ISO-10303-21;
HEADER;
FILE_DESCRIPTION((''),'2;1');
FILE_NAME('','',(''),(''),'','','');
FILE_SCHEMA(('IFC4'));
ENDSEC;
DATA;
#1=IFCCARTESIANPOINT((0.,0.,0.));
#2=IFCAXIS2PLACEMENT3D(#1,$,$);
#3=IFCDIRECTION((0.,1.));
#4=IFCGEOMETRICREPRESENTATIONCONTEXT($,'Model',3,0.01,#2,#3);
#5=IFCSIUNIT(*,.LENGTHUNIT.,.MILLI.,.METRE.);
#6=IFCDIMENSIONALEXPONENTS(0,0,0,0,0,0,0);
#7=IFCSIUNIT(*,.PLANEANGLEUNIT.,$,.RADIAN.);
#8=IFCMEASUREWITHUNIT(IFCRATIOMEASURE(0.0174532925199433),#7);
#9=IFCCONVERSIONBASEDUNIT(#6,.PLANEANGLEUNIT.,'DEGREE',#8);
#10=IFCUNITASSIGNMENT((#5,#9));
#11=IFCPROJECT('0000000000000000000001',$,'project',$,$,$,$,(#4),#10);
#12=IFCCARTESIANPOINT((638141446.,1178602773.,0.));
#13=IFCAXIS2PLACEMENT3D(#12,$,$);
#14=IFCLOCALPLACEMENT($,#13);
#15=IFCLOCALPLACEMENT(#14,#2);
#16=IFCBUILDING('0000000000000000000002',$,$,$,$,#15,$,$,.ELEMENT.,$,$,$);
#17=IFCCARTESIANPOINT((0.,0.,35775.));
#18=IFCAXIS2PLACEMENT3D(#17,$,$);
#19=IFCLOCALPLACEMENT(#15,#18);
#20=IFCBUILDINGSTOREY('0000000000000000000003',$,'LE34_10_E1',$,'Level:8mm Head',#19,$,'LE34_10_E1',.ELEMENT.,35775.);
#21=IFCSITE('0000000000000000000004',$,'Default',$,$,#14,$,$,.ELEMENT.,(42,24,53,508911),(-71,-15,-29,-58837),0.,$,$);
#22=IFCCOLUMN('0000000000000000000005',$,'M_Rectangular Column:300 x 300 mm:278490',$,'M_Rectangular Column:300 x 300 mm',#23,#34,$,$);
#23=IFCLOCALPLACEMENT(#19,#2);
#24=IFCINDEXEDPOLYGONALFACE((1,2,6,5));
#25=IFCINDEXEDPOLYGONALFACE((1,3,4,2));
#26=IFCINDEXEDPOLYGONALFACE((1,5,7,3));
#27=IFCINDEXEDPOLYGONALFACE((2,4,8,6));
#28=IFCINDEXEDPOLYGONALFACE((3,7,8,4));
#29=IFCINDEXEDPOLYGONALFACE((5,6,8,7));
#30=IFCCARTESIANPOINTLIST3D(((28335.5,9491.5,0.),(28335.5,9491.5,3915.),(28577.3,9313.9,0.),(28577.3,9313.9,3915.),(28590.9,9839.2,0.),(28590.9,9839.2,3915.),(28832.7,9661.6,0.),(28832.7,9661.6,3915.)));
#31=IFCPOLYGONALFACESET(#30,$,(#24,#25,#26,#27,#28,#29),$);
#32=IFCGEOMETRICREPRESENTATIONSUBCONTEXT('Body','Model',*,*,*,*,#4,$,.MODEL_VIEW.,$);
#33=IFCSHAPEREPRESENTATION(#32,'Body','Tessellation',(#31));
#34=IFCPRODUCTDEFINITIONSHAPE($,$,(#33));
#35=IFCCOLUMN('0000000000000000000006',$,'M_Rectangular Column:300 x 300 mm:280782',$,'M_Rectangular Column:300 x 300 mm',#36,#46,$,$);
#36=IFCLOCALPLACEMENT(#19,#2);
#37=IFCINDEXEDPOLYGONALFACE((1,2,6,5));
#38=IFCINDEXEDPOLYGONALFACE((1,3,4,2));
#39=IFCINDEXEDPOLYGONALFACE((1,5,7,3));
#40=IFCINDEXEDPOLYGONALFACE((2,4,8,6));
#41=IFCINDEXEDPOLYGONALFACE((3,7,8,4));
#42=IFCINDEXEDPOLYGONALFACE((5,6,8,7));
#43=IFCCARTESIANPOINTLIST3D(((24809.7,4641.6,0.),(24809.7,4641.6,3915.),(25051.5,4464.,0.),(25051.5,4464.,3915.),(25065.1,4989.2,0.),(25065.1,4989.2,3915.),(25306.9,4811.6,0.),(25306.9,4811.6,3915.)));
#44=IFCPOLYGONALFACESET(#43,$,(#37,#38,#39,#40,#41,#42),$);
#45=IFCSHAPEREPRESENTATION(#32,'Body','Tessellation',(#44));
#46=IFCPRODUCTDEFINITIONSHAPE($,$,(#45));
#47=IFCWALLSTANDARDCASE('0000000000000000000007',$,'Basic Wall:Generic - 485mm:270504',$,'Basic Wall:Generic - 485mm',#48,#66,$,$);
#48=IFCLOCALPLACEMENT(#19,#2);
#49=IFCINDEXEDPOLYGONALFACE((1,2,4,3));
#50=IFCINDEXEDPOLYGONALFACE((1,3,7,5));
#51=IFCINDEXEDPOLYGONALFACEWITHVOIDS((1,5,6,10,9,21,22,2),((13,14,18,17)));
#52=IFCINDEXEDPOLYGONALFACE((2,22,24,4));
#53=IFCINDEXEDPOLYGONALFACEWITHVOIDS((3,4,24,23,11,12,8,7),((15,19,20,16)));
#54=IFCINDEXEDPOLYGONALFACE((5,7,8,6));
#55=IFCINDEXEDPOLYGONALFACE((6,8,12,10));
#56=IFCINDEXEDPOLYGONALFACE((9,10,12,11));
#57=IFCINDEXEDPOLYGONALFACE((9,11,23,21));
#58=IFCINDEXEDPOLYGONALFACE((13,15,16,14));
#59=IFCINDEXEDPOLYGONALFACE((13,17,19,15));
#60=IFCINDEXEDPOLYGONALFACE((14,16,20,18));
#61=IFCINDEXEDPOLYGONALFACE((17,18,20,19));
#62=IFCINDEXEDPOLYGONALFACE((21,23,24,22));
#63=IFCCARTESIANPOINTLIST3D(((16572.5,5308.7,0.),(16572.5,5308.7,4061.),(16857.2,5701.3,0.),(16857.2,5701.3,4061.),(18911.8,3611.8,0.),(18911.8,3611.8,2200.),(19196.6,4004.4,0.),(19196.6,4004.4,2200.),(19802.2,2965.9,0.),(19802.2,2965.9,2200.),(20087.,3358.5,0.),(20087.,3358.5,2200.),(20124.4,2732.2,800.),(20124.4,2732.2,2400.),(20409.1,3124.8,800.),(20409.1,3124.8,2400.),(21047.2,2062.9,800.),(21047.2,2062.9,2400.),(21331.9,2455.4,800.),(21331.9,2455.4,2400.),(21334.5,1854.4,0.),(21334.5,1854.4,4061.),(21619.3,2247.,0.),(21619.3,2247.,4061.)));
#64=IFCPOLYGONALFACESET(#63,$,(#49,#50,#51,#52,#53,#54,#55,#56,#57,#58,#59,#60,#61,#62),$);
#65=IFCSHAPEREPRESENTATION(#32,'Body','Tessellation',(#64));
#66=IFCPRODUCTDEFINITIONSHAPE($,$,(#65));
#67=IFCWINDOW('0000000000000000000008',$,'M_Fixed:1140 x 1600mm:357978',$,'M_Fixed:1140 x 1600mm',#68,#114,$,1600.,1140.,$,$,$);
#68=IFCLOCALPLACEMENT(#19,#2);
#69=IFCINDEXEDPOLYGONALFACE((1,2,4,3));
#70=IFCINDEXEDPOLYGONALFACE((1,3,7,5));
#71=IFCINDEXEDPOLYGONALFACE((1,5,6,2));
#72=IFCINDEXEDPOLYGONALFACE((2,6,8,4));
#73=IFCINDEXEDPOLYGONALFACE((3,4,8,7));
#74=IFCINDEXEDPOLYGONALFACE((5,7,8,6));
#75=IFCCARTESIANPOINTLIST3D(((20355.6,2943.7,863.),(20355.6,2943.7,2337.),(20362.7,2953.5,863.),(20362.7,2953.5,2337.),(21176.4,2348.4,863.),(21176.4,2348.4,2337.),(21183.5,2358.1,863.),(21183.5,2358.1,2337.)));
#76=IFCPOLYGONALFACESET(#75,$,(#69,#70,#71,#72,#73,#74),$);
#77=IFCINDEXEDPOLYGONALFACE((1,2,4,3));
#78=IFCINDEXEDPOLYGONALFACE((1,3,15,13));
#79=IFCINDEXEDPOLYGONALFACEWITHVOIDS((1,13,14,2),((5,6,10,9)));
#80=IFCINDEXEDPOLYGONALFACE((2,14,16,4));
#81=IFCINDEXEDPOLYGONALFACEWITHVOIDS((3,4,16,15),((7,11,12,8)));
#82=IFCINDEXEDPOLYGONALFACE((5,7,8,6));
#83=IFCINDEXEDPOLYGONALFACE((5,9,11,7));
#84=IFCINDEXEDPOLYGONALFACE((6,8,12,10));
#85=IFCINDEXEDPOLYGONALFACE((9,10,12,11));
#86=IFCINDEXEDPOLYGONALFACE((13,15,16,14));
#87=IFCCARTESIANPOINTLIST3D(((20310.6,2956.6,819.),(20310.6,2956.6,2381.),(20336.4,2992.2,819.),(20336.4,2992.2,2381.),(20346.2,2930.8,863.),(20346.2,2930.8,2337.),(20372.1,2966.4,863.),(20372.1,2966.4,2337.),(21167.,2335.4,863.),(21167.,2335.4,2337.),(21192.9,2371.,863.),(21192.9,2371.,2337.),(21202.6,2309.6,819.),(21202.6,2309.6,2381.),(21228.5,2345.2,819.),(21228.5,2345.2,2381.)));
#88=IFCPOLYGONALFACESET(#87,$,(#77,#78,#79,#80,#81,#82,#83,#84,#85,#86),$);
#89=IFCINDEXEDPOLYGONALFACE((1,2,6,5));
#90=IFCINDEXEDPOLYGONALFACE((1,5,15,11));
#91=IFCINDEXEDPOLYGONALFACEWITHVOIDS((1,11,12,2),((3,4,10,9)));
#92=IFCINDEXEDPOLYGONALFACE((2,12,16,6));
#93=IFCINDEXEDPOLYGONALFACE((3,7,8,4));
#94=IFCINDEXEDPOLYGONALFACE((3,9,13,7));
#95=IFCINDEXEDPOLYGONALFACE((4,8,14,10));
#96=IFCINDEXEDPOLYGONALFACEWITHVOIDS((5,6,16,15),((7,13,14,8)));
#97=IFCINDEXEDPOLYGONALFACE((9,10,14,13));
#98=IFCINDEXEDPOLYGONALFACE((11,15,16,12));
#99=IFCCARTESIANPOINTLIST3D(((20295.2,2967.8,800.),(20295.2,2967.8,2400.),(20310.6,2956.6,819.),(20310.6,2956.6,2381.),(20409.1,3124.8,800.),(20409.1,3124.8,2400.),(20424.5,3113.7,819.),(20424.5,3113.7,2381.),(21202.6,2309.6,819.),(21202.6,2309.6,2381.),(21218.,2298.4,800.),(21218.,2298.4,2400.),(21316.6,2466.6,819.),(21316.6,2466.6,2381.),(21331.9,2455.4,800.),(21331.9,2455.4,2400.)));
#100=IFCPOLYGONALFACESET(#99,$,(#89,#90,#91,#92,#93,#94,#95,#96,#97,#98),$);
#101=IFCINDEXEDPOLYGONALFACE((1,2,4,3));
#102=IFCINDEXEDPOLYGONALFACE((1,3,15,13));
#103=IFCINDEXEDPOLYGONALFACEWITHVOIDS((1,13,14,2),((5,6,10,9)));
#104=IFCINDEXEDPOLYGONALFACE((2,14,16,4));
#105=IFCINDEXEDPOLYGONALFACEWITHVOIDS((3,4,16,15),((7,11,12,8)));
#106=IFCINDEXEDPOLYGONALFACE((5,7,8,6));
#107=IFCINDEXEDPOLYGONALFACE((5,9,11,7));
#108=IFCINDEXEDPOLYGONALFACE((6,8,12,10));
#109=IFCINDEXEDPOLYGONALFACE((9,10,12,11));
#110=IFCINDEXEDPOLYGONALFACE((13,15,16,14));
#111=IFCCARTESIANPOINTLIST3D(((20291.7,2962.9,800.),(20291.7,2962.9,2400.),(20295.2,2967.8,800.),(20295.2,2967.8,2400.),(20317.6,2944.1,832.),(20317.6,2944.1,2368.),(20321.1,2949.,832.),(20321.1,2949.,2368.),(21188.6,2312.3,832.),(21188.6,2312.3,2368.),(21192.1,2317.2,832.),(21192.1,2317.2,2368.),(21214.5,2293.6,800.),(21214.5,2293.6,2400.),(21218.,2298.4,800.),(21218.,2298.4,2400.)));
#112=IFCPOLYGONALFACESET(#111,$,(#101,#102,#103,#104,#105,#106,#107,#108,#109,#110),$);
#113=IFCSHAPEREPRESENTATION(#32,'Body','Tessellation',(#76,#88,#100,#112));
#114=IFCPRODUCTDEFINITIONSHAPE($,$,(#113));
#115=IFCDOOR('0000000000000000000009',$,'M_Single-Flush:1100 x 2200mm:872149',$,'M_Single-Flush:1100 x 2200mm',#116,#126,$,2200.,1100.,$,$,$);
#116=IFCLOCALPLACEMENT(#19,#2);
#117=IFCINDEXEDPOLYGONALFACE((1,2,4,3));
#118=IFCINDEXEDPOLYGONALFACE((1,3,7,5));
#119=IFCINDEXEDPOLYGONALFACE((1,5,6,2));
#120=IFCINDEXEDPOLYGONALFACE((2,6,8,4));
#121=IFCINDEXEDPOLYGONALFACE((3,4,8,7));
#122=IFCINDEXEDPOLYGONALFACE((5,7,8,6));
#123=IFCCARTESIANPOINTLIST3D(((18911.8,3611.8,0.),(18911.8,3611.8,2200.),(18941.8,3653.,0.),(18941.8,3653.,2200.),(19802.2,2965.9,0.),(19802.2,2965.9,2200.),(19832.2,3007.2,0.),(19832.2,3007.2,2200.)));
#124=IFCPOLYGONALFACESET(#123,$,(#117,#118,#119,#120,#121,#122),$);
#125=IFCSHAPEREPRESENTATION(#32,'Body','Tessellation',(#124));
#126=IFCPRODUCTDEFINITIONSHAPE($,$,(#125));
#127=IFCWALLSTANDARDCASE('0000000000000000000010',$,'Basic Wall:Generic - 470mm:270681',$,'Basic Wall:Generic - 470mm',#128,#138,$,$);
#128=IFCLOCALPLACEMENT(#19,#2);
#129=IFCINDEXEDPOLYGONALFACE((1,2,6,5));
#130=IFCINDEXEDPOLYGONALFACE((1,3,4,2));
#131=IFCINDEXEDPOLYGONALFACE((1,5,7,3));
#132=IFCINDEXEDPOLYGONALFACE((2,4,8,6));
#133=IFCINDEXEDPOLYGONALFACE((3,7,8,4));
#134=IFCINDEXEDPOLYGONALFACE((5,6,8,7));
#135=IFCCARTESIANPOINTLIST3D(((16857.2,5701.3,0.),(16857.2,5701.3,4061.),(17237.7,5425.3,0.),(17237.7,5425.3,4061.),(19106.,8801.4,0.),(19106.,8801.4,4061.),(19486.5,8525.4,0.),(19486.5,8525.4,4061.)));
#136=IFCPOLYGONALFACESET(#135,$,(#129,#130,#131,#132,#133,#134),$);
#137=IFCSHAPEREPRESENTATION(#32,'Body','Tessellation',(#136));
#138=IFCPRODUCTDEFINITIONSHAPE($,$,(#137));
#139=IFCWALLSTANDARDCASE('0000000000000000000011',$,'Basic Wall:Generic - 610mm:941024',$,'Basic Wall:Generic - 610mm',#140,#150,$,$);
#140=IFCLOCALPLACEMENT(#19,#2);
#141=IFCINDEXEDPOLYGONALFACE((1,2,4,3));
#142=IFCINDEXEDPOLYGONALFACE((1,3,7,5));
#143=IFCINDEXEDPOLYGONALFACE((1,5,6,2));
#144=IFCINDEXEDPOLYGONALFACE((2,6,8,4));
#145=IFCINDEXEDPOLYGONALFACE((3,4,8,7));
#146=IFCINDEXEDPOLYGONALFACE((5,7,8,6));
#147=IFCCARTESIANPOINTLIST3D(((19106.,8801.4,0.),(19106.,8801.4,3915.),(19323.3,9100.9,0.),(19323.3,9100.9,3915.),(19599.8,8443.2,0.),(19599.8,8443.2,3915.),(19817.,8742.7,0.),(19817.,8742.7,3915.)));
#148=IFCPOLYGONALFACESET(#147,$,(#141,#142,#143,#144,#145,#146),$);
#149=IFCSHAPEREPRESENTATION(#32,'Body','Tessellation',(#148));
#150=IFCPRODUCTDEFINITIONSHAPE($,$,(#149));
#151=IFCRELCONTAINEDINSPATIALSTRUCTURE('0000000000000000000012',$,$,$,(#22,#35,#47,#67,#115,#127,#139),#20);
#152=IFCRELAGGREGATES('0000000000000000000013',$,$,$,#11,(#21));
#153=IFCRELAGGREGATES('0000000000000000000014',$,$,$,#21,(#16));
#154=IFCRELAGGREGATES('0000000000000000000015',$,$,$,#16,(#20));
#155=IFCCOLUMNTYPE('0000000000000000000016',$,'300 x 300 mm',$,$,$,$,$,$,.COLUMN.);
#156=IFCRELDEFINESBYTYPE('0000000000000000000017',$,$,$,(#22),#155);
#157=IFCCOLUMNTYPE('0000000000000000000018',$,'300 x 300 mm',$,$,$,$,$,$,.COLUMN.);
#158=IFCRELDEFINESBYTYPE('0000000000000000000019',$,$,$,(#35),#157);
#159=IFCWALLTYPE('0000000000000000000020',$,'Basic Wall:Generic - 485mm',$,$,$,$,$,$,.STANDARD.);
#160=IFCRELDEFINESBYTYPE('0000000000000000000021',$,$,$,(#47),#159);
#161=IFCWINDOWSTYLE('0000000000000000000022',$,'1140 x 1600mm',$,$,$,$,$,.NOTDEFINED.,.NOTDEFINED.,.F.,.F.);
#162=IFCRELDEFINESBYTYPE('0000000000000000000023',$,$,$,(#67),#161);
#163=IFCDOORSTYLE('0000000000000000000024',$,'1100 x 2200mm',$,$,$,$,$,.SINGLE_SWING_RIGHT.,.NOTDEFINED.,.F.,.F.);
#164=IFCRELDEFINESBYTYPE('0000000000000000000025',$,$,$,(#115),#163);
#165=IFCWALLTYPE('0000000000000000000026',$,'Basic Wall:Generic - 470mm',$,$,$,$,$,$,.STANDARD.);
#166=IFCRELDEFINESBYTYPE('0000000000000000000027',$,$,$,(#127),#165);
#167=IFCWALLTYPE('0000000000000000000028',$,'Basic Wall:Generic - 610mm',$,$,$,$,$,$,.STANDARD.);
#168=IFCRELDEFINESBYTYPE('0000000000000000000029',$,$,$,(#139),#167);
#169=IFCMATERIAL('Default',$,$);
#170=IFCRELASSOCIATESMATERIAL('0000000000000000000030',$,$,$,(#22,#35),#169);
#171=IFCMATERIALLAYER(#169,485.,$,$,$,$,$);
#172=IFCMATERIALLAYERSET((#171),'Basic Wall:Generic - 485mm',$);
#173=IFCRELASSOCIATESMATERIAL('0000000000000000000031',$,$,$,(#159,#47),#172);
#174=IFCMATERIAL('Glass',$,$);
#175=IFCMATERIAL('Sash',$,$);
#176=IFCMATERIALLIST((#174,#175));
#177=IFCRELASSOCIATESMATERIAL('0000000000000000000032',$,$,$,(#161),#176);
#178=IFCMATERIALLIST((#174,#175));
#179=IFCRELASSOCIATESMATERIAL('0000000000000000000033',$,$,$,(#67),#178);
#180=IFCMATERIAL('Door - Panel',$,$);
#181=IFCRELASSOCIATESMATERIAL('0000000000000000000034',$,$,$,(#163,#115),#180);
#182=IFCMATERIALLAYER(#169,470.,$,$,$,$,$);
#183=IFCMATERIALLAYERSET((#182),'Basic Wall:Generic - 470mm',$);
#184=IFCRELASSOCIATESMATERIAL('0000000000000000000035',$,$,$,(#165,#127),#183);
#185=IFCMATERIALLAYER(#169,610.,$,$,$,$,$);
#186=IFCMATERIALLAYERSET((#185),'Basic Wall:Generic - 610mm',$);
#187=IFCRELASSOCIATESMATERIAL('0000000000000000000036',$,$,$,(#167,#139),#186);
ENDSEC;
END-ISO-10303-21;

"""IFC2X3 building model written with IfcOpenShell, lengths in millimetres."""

from ifc_helpers import new_model, entity, si_unit, converted_unit, direction, frame, frame_2d, origin, place, context, subcontext, project, spatial, polyline, rectangle, outline, extrude, source, transform, mapped, material, material_list, layer, layer_set, layer_usage, type_object, type_shapes, element, fill, save


model = new_model("IFC2X3")

# Units and contexts
model_context = context("Model", 3, precision=0.01, world=origin(), true_north=direction((0.0, 1.0)))
body_context = subcontext(model_context, "Body", "Model", "MODEL_VIEW")
ifc_project = project(units=[si_unit("LENGTHUNIT", "METRE", prefix="MILLI"), converted_unit("PLANEANGLEUNIT", "DEGREE", entity("IfcRatioMeasure", 0.0174532925199433), si_unit("PLANEANGLEUNIT", "RADIAN"), dimensions=[0, 0, 0, 0, 0, 0, 0])], contexts=[model_context])

# Site, building, storey
site_placement = place(None, frame((638141446.0, 1178602773.0, 0.0)))
site = spatial("IfcSite", under=ifc_project, at=site_placement, Name="Default", CompositionType="ELEMENT", RefLatitude=(42, 24, 53, 508911), RefLongitude=(-71, -15, -29, -58837), RefElevation=0.0)
building_placement = place(site_placement, origin())
building = spatial("IfcBuilding", under=site, at=building_placement, CompositionType="ELEMENT")
storey_placement = place(building_placement, frame((0.0, 0.0, 35775.0)))
storey = spatial("IfcBuildingStorey", under=building, at=storey_placement, Name="LE34_10_E1", ObjectType="Level:8mm Head", LongName="LE34_10_E1", CompositionType="ELEMENT", Elevation=35775.0)

# Columns
ifc_material_1 = material(Name="Default")
column_type_1 = type_object("IfcColumnType", Name="300 x 300 mm", PredefinedType="COLUMN")
shared_shape_1 = source(origin(), body_context, "Body", "SweptSolid", [
    extrude(rectangle(XDim=300.0, YDim=431.4, at=frame_2d((0.0, 0.0), x_axis=(1.0, 0.0))), frame((28584.1, 9576.6, 35775.0), z_axis=(0.0, 0.0, 1.0), x_axis=(-0.805916, 0.592029, 0.0)), (0.0, 0.0, 1.0), 3915.0),
])
type_shapes(column_type_1, [shared_shape_1])
column_1_placement = place(storey_placement, frame((0.0, 0.0, -35775.0)))
element("IfcColumn", 1, at=column_1_placement, inside=storey, type_object=column_type_1, material=ifc_material_1, Name="M_Rectangular Column:300 x 300 mm:278490", ObjectType="M_Rectangular Column:300 x 300 mm", context=body_context, shape_type="MappedRepresentation", body=[
    mapped(shared_shape_1, transform((0.0, 0.0, 0.0), scale=1.0)),
])
column_type_2 = type_object("IfcColumnType", Name="300 x 300 mm", PredefinedType="COLUMN")
shared_shape_2 = source(origin(), body_context, "Body", "SweptSolid", [
    extrude(rectangle(XDim=300.0, YDim=431.4, at=frame_2d((0.0, 0.0), x_axis=(1.0, 0.0))), frame((25058.3, 4726.6, 35775.0), z_axis=(0.0, 0.0, 1.0), x_axis=(-0.805916, 0.592029, 0.0)), (0.0, 0.0, 1.0), 3915.0),
])
type_shapes(column_type_2, [shared_shape_2])
column_2_placement = place(storey_placement, frame((0.0, 0.0, -35775.0)))
element("IfcColumn", 2, at=column_2_placement, inside=storey, type_object=column_type_2, material=ifc_material_1, Name="M_Rectangular Column:300 x 300 mm:280782", ObjectType="M_Rectangular Column:300 x 300 mm", context=body_context, shape_type="MappedRepresentation", body=[
    mapped(shared_shape_2, transform((0.0, 0.0, 0.0), scale=1.0)),
])

# Wall, openings, window, door
ifc_layer_1 = layer(ifc_material_1, 485.0)
ifc_layer_set_1 = layer_set([ifc_layer_1], Name="Basic Wall:Generic - 485mm")
ifc_layer_usage_1 = layer_usage(ifc_layer_set_1, "AXIS2", "NEGATIVE", 242.5)
wall_type_1 = type_object("IfcWallType", Name="Basic Wall:Generic - 485mm", PredefinedType="STANDARD", material=ifc_layer_set_1)
wall_1_placement = place(storey_placement, frame((16714.9, 5505.0, 0.0), z_axis=(0.0, 0.0, 1.0), x_axis=(0.809468, -0.587164, 0.0)))
wall_1 = element("IfcWallStandardCase", 3, at=wall_1_placement, inside=storey, type_object=wall_type_1, material=ifc_layer_usage_1, Name="Basic Wall:Generic - 485mm:270504", ObjectType="Basic Wall:Generic - 485mm", context=body_context, shape_type="SweptSolid", body=[
    extrude(rectangle(XDim=5883.0, YDim=485.0, at=frame_2d((2941.5, 0.0), x_axis=(-1.0, 0.0))), origin(), (0.0, 0.0, 1.0), 4061.0),
])
opening_1_placement = place(wall_1_placement, frame((3990.0, 242.5, 0.0)))
opening_1 = element("IfcOpeningElement", 4, at=opening_1_placement, cuts=wall_1, ObjectType="Opening", context=body_context, shape_type="SweptSolid", body=[
    extrude(rectangle(XDim=1100.0, YDim=2200.0, at=frame_2d((1100.0, 550.0), x_axis=(0.0, 1.0))), frame((0.0, 0.0, 0.0), z_axis=(0.0, -1.0, 0.0), x_axis=(0.0, 0.0, 1.0)), (0.0, 0.0, 1.0), 485.0),
])
opening_2_placement = place(wall_1_placement, frame((4387.9, -242.5, 800.0)))
opening_2 = element("IfcOpeningElement", 5, at=opening_2_placement, cuts=wall_1, ObjectType="Opening", context=body_context, shape_type="SweptSolid", body=[
    extrude(rectangle(XDim=1600.0, YDim=1140.0, at=frame_2d((800.0, 570.0), x_axis=(1.0, 0.0))), frame((0.0, 0.0, 0.0), z_axis=(0.0, 1.0, 0.0), x_axis=(0.0, 0.0, 1.0)), (0.0, 0.0, 1.0), 485.0),
])
ifc_material_2 = material(Name="Glass")
ifc_material_3 = material(Name="Sash")
ifc_material_list_1 = material_list([ifc_material_2, ifc_material_3])
ifc_material_list_2 = material_list([ifc_material_2, ifc_material_3])
window_style = type_object("IfcWindowStyle", Name="1140 x 1600mm", ConstructionType="NOTDEFINED", OperationType="NOTDEFINED", ParameterTakesPrecedence=False, Sizeable=False, material=ifc_material_list_2)
shared_shape_3 = source(origin(), body_context, "Body", "SweptSolid", [
    extrude(rectangle(XDim=12.0, YDim=1014.0, at=frame_2d((0.0, 0.0), x_axis=(1.0, 0.0))), frame((570.0, 313.0, 63.0), z_axis=(0.0, 0.0, 1.0), x_axis=(0.0, -1.0, 0.0)), (0.0, 0.0, 1.0), 1474.0),
    extrude(outline(polyline([(-551.0, -781.0), (551.0, -781.0), (551.0, 781.0), (-551.0, 781.0), (-551.0, -781.0)]), holes=[polyline([(-507.0, -737.0), (-507.0, 737.0), (507.0, 737.0), (507.0, -737.0), (-507.0, -737.0)])]), frame((570.0, 291.0, 800.0), z_axis=(0.0, 1.0, 0.0), x_axis=(1.0, 0.0, 0.0)), (0.0, 0.0, 1.0), 44.0),
    extrude(outline(polyline([(-570.0, -800.0), (570.0, -800.0), (570.0, 800.0), (-570.0, 800.0), (-570.0, -800.0)]), holes=[polyline([(-551.0, -781.0), (-551.0, 781.0), (551.0, 781.0), (551.0, -781.0), (-551.0, -781.0)])]), frame((570.0, 291.0, 800.0), z_axis=(0.0, 1.0, 0.0), x_axis=(1.0, 0.0, 0.0)), (0.0, 0.0, 1.0), 194.0),
    extrude(outline(polyline([(-570.0, -800.0), (570.0, -800.0), (570.0, 800.0), (-570.0, 800.0), (-570.0, -800.0)]), holes=[polyline([(-538.0, -768.0), (-538.0, 768.0), (538.0, 768.0), (538.0, -768.0), (-538.0, -768.0)])]), frame((570.0, 285.0, 800.0), z_axis=(0.0, 1.0, 0.0), x_axis=(1.0, 0.0, 0.0)), (0.0, 0.0, 1.0), 6.0),
])
type_shapes(window_style, [shared_shape_3])
window_placement = place(opening_2_placement, origin())
window = element("IfcWindow", 6, at=window_placement, inside=storey, type_object=window_style, material=ifc_material_list_1, Name="M_Fixed:1140 x 1600mm:357978", ObjectType="M_Fixed:1140 x 1600mm", OverallHeight=1600.0, OverallWidth=1140.0, context=body_context, shape_type="MappedRepresentation", body=[
    mapped(shared_shape_3, transform((0.0, 0.0, 0.0), scale=1.0)),
])
fill(opening_2, window)
ifc_material_4 = material(Name="Door - Panel")
door_style = type_object("IfcDoorStyle", Name="1100 x 2200mm", ConstructionType="NOTDEFINED", OperationType="SINGLE_SWING_RIGHT", ParameterTakesPrecedence=False, Sizeable=False, material=ifc_material_4)
shared_shape_4 = source(origin(), body_context, "Body", "SweptSolid", [
    extrude(rectangle(XDim=51.0, YDim=1100.0, at=frame_2d((0.0, 0.0), x_axis=(1.0, 0.0))), frame((550.0, 459.5, 0.0), z_axis=(0.0, 0.0, 1.0), x_axis=(0.0, 1.0, 0.0)), (0.0, 0.0, 1.0), 2200.0),
])
type_shapes(door_style, [shared_shape_4])
door_placement = place(opening_1_placement, frame((0.0, 0.0, 0.0), z_axis=(0.0, 0.0, 1.0), x_axis=(-1.0, 0.0, 0.0)))
door = element("IfcDoor", 7, at=door_placement, inside=storey, type_object=door_style, material=ifc_material_4, Name="M_Single-Flush:1100 x 2200mm:872149", ObjectType="M_Single-Flush:1100 x 2200mm", OverallHeight=2200.0, OverallWidth=1100.0, context=body_context, shape_type="MappedRepresentation", body=[
    mapped(shared_shape_4, transform((0.0, 0.0, 0.0), scale=1.0)),
])
fill(opening_1, door)

# Walls
ifc_layer_2 = layer(ifc_material_1, 470.0)
ifc_layer_set_2 = layer_set([ifc_layer_2], Name="Basic Wall:Generic - 470mm")
ifc_layer_usage_2 = layer_usage(ifc_layer_set_2, "AXIS2", "NEGATIVE", 235.0)
wall_type_2 = type_object("IfcWallType", Name="Basic Wall:Generic - 470mm", PredefinedType="STANDARD", material=ifc_layer_set_2)
wall_2_placement = place(storey_placement, frame((17047.5, 5563.3, 0.0), z_axis=(0.0, 0.0, 1.0), x_axis=(0.587164, 0.809468, 0.0)))
element("IfcWallStandardCase", 8, at=wall_2_placement, inside=storey, type_object=wall_type_2, material=ifc_layer_usage_2, Name="Basic Wall:Generic - 470mm:270681", ObjectType="Basic Wall:Generic - 470mm", context=body_context, shape_type="SweptSolid", body=[
    extrude(rectangle(XDim=3829.9, YDim=470.0, at=frame_2d((1914.9, 0.0), x_axis=(-1.0, 0.0))), origin(), (0.0, 0.0, 1.0), 4061.0),
])
ifc_layer_3 = layer(ifc_material_1, 610.0)
ifc_layer_set_3 = layer_set([ifc_layer_3], Name="Basic Wall:Generic - 610mm")
ifc_layer_usage_3 = layer_usage(ifc_layer_set_3, "AXIS2", "NEGATIVE", 305.0)
wall_type_3 = type_object("IfcWallType", Name="Basic Wall:Generic - 610mm", PredefinedType="STANDARD", material=ifc_layer_set_3)
wall_3_placement = place(storey_placement, frame((19352.9, 8622.3, 0.0), z_axis=(0.0, 0.0, 1.0), x_axis=(0.587164, 0.809468, 0.0)))
element("IfcWallStandardCase", 9, at=wall_3_placement, inside=storey, type_object=wall_type_3, material=ifc_layer_usage_3, Name="Basic Wall:Generic - 610mm:941024", ObjectType="Basic Wall:Generic - 610mm", context=body_context, shape_type="SweptSolid", body=[
    extrude(rectangle(XDim=370.0, YDim=610.0, at=frame_2d((185.0, 0.0), x_axis=(-1.0, 0.0))), origin(), (0.0, 0.0, 1.0), 3915.0),
])

save(model, "model.ifc")
